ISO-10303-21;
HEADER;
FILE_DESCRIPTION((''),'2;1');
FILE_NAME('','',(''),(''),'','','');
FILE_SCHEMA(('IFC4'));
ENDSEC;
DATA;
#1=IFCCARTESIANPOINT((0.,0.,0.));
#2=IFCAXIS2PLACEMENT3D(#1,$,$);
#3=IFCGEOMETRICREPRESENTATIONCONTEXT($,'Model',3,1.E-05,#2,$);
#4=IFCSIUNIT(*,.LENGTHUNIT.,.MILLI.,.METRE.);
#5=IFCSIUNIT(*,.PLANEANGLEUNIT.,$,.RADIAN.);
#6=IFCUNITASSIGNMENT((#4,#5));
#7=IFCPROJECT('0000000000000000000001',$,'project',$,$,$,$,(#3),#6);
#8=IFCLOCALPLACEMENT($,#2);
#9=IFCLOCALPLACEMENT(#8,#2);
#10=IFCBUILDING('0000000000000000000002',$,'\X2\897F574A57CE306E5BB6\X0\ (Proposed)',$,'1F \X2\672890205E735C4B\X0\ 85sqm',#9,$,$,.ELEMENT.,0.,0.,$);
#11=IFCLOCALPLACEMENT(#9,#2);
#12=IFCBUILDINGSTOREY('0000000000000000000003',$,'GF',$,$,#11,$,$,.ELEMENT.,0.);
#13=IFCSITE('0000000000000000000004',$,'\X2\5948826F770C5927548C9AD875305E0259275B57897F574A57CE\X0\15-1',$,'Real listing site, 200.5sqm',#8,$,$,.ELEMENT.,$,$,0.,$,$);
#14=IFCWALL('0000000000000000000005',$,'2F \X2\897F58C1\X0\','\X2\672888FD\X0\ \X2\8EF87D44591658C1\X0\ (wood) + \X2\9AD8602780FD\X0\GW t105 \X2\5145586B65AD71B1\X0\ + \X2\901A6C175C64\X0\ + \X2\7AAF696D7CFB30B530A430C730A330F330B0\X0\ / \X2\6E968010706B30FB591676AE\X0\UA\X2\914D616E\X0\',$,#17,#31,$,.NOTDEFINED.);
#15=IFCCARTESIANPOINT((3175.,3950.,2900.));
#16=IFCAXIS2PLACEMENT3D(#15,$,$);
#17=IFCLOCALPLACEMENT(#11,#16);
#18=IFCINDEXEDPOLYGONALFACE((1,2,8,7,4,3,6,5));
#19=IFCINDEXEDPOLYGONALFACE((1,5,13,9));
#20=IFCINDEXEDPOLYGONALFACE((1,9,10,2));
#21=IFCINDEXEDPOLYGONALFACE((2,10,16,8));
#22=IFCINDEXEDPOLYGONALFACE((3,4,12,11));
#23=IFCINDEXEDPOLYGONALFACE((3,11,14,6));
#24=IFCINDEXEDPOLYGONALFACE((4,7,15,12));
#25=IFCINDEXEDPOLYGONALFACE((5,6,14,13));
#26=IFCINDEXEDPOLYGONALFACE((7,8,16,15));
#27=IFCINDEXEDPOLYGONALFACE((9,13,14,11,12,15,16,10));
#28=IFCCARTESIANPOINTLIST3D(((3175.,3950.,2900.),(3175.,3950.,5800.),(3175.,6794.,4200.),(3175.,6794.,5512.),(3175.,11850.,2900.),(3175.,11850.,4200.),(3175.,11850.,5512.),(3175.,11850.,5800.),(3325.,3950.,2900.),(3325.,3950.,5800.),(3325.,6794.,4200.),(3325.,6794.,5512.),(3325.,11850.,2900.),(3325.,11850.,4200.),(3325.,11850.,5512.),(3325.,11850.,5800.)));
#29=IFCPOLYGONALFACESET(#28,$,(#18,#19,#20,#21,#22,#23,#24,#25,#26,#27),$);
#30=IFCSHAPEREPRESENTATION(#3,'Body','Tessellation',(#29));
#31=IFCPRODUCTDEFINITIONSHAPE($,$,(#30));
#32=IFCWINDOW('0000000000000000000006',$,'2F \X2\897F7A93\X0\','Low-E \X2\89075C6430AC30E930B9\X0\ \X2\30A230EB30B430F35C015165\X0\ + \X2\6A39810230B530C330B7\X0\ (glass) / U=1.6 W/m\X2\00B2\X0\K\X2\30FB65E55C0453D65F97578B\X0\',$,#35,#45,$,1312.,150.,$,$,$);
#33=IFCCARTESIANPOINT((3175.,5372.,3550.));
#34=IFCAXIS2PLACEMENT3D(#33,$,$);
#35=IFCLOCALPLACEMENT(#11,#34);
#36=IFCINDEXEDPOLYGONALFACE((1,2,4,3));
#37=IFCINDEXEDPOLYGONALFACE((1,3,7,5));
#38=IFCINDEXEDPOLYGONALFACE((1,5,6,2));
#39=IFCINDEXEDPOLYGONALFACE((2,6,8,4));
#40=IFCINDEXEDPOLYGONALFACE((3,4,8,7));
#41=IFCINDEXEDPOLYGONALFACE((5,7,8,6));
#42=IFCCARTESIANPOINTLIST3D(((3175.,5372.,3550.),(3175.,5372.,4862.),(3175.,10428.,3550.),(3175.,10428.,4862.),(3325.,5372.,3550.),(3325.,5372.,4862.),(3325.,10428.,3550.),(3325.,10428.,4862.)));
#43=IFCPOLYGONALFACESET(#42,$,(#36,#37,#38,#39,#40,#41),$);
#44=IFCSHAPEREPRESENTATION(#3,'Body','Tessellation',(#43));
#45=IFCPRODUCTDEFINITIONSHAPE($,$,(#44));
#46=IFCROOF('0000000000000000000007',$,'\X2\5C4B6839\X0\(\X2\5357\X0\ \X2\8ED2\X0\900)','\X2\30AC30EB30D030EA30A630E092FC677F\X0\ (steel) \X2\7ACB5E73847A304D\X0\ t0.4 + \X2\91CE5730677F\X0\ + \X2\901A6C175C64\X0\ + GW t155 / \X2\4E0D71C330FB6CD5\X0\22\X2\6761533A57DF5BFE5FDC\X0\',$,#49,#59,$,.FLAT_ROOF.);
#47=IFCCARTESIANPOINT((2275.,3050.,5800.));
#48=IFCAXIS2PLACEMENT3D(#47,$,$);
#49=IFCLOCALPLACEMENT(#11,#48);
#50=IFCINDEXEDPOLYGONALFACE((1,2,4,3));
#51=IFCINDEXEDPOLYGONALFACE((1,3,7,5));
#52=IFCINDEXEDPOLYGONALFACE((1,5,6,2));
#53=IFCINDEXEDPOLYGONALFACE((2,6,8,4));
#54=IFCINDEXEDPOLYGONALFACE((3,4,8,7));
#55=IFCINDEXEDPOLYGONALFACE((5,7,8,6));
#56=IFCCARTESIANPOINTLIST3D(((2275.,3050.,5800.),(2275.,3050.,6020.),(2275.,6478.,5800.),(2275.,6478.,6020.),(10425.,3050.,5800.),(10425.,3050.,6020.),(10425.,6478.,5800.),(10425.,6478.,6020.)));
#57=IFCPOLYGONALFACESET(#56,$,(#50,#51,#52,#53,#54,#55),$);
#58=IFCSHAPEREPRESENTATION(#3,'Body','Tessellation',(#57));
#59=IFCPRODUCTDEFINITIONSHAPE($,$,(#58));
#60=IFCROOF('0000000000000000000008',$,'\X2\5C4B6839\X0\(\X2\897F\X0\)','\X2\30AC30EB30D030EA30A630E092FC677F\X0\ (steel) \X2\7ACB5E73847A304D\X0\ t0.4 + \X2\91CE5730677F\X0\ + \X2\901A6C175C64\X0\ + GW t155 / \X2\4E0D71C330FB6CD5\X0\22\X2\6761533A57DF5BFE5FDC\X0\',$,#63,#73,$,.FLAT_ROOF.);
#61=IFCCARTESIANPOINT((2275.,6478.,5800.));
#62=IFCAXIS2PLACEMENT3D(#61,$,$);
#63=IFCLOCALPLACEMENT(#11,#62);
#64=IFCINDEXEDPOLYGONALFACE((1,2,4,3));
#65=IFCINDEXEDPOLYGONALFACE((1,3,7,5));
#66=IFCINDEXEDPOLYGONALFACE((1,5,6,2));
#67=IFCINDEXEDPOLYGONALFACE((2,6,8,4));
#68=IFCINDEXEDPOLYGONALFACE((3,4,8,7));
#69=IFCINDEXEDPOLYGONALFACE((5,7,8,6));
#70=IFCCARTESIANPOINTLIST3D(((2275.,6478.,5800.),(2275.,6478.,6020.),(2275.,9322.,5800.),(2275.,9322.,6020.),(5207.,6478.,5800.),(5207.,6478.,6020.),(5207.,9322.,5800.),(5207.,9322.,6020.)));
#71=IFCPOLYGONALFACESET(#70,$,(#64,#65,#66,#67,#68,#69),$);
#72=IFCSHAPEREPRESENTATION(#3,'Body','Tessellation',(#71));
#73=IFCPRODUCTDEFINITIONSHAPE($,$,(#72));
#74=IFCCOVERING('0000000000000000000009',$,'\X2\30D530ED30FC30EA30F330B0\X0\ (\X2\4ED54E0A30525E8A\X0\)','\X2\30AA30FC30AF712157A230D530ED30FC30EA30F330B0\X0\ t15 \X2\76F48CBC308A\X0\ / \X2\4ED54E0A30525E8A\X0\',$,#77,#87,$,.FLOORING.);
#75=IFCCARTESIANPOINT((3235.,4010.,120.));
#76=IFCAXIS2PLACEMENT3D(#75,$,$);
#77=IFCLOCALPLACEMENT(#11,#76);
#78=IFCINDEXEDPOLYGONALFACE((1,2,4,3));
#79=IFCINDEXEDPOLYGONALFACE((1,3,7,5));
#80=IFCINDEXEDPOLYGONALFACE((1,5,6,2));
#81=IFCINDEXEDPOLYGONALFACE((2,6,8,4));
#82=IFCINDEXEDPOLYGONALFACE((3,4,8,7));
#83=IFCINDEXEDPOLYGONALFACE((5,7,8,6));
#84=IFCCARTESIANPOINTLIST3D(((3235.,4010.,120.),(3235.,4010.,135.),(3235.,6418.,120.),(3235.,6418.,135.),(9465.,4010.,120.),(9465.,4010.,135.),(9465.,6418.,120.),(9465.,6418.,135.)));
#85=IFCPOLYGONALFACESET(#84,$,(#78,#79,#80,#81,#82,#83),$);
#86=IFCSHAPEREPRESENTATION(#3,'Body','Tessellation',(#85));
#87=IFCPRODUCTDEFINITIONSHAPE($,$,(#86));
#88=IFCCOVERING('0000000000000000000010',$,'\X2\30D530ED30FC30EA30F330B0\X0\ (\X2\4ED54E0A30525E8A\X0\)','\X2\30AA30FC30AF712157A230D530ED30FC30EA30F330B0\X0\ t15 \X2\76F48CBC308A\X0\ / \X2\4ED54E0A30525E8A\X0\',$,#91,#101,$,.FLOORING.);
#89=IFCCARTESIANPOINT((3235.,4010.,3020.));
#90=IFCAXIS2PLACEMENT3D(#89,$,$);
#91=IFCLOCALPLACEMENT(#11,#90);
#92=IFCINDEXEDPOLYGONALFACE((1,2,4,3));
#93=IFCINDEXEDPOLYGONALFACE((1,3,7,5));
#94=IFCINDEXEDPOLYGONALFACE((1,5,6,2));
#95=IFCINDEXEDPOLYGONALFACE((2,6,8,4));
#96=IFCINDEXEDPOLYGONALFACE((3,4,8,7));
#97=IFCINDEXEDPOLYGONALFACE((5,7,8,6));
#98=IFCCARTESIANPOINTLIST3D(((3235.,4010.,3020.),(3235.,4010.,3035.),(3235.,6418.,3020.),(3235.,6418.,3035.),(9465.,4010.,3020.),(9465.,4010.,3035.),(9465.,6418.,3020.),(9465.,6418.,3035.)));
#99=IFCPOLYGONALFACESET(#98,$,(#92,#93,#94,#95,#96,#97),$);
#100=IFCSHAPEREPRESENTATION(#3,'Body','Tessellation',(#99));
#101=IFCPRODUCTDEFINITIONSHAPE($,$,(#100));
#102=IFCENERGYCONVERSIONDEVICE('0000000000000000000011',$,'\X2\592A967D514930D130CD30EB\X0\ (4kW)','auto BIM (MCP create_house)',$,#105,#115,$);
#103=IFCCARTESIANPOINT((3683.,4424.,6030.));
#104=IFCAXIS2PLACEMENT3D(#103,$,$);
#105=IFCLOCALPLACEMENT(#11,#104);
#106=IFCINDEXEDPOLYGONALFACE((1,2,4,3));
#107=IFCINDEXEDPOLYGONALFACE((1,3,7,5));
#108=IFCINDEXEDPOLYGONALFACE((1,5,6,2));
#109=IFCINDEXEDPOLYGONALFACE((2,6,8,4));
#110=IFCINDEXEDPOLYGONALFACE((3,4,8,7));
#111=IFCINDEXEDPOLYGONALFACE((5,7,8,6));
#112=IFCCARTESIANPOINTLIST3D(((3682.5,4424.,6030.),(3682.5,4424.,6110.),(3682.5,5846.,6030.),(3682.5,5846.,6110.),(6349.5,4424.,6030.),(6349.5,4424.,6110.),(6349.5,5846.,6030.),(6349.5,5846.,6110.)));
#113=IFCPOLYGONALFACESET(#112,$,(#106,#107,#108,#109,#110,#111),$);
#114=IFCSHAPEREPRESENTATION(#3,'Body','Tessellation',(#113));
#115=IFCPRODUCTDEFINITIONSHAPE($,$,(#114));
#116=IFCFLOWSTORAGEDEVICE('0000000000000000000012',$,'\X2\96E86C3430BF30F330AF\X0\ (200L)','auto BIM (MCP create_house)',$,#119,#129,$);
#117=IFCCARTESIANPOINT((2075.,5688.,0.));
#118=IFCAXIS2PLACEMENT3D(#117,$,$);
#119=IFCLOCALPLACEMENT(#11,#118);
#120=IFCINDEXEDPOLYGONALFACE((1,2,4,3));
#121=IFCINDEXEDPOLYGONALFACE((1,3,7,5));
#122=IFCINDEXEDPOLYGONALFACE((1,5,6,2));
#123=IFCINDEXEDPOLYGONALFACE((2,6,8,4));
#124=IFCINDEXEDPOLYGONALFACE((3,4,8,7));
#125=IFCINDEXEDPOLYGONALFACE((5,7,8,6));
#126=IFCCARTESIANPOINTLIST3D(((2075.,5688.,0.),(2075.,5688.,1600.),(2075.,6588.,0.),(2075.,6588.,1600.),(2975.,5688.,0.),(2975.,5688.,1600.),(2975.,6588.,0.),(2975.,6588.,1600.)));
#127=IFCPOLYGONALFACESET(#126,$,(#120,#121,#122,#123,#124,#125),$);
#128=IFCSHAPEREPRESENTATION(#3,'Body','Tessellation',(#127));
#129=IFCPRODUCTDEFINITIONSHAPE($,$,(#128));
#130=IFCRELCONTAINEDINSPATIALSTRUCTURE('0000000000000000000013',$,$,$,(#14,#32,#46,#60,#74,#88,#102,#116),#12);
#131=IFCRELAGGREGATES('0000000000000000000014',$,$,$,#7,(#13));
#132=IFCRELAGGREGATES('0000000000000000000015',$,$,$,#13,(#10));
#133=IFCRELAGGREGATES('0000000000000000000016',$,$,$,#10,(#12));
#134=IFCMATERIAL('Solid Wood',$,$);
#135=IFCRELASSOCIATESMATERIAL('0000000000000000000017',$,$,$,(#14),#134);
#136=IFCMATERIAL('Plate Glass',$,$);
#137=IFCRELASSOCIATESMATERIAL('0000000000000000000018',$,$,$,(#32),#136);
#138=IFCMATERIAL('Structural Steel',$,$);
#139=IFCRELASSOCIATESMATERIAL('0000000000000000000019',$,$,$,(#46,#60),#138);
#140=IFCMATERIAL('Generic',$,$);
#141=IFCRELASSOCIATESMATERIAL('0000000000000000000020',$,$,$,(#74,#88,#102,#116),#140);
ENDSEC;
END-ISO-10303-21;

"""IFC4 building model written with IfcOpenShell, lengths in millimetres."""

from ifc_helpers import new_model, si_unit, frame, frame_2d, origin, place, context, project, spatial, rectangle, extrude, material, element, fill, save


model = new_model("IFC4")

# Units and contexts
model_context = context("Model", 3, precision=1e-05, world=origin())
ifc_project = project(units=[si_unit("LENGTHUNIT", "METRE", prefix="MILLI"), si_unit("PLANEANGLEUNIT", "RADIAN")], contexts=[model_context])

# Site, building, storey
site_placement = place(None, origin())
site = spatial("IfcSite", under=ifc_project, at=site_placement, Name="奈良県大和高田市大字西坊城15-1", ObjectType="Real listing site, 200.5sqm", CompositionType="ELEMENT", RefElevation=0.0)
building_placement = place(site_placement, origin())
building = spatial("IfcBuilding", under=site, at=building_placement, Name="西坊城の家 (Proposed)", ObjectType="1F 木造平屋 85sqm", CompositionType="ELEMENT", ElevationOfRefHeight=0.0, ElevationOfTerrain=0.0)
storey_placement = place(building_placement, origin())
storey = spatial("IfcBuildingStorey", under=building, at=storey_placement, Name="GF", CompositionType="ELEMENT", Elevation=0.0)

# Shared definitions
ifc_material_1 = material(Name="Solid Wood")
ifc_material_2 = material(Name="Generic")

# Shared definitions
ifc_material_3 = material(Name="Plate Glass")

# Wall, opening, window
wall_1_placement = place(storey_placement, frame((3175.0, 3950.0, 2900.0)))
wall_1 = element("IfcWall", 1, at=wall_1_placement, inside=storey, material=ifc_material_1, Name="2F 西壁", Description="木製 軸組外壁 (wood) + 高性能GW t105 充填断熱 + 通気層 + 窯業系サイディング / 準耐火・外皮UA配慮", PredefinedType="NOTDEFINED", context=model_context, shape_type="SweptSolid", body=[
    extrude(rectangle(XDim=150.0, YDim=7900.0, at=frame_2d((75.0, 3950.0))), frame((3175.0, 3950.0, 2900.0)), (0.0, 0.0, 1.0), 2900.0),
])
opening_1_placement = place(storey_placement, frame((3175.0, 5372.0, 3550.0)))
opening_1 = element("IfcOpeningElement", 2, at=opening_1_placement, cuts=wall_1, PredefinedType="NOTDEFINED", context=model_context, shape_type="SweptSolid", body=[
    extrude(rectangle(XDim=150.0, YDim=5056.0, at=frame_2d((75.0, 2528.0))), frame((3175.0, 5372.0, 3550.0)), (0.0, 0.0, 1.0), 1312.0),
])
window_1_placement = place(storey_placement, frame((3175.0, 5372.0, 3550.0)))
window_1 = element("IfcWindow", 3, at=window_1_placement, inside=storey, material=ifc_material_3, Name="2F 西窓", Description="Low-E 複層ガラス アルゴン封入 + 樹脂サッシ (glass) / U=1.6 W/m²K・日射取得型", OverallHeight=1312.0, OverallWidth=150.0, context=model_context, shape_type="SweptSolid", body=[
    extrude(rectangle(XDim=150.0, YDim=5056.0, at=frame_2d((75.0, 2528.0))), frame((3175.0, 5372.0, 3550.0)), (0.0, 0.0, 1.0), 1312.0),
])
fill(opening_1, window_1)

# Roofs
ifc_material_4 = material(Name="Structural Steel")
roof_1_placement = place(storey_placement, frame((2275.0, 3050.0, 5800.0)))
element("IfcRoof", 4, at=roof_1_placement, inside=storey, material=ifc_material_4, Name="屋根(南 軒900)", Description="ガルバリウム鋼板 (steel) 立平葺き t0.4 + 野地板 + 通気層 + GW t155 / 不燃・法22条区域対応", PredefinedType="FLAT_ROOF", context=model_context, shape_type="SweptSolid", body=[
    extrude(rectangle(XDim=8150.0, YDim=3428.0, at=frame_2d((4075.0, 1714.0))), frame((2275.0, 3050.0, 5800.0)), (0.0, 0.0, 1.0), 220.0),
])
roof_2_placement = place(storey_placement, frame((2275.0, 6478.0, 5800.0)))
element("IfcRoof", 5, at=roof_2_placement, inside=storey, material=ifc_material_4, Name="屋根(西)", Description="ガルバリウム鋼板 (steel) 立平葺き t0.4 + 野地板 + 通気層 + GW t155 / 不燃・法22条区域対応", PredefinedType="FLAT_ROOF", context=model_context, shape_type="SweptSolid", body=[
    extrude(rectangle(XDim=2932.0, YDim=2844.0, at=frame_2d((1466.0, 1422.0))), frame((2275.0, 6478.0, 5800.0)), (0.0, 0.0, 1.0), 220.0),
])

# Coverings
covering_1_placement = place(storey_placement, frame((3235.0, 4010.0, 120.0)))
element("IfcCovering", 6, at=covering_1_placement, inside=storey, material=ifc_material_2, Name="フローリング (仕上げ床)", Description="オーク無垢フローリング t15 直貼り / 仕上げ床", PredefinedType="FLOORING", context=model_context, shape_type="SweptSolid", body=[
    extrude(rectangle(XDim=6230.0, YDim=2408.0, at=frame_2d((3115.0, 1204.0))), frame((3235.0, 4010.0, 120.0)), (0.0, 0.0, 1.0), 15.0),
])
covering_2_placement = place(storey_placement, frame((3235.0, 4010.0, 3020.0)))
element("IfcCovering", 7, at=covering_2_placement, inside=storey, material=ifc_material_2, Name="フローリング (仕上げ床)", Description="オーク無垢フローリング t15 直貼り / 仕上げ床", PredefinedType="FLOORING", context=model_context, shape_type="SweptSolid", body=[
    extrude(rectangle(XDim=6230.0, YDim=2408.0, at=frame_2d((3115.0, 1204.0))), frame((3235.0, 4010.0, 3020.0)), (0.0, 0.0, 1.0), 15.0),
])

# Energy conversion device
energy_conversion_device_placement = place(storey_placement, frame((3683.0, 4424.0, 6030.0)))
element("IfcEnergyConversionDevice", 8, at=energy_conversion_device_placement, inside=storey, material=ifc_material_2, Name="太陽光パネル (4kW)", Description="auto BIM (MCP create_house)", context=model_context, shape_type="SweptSolid", body=[
    extrude(rectangle(XDim=2667.0, YDim=1422.0, at=frame_2d((1333.0, 711.0))), frame((3683.0, 4424.0, 6030.0)), (0.0, 0.0, 1.0), 80.0),
])

# Flow storage device
flow_storage_device_placement = place(storey_placement, frame((2075.0, 5688.0, 0.0)))
element("IfcFlowStorageDevice", 9, at=flow_storage_device_placement, inside=storey, material=ifc_material_2, Name="雨水タンク (200L)", Description="auto BIM (MCP create_house)", context=model_context, shape_type="SweptSolid", body=[
    extrude(rectangle(XDim=900.0, YDim=900.0, at=frame_2d((450.0, 450.0))), frame((2075.0, 5688.0, 0.0)), (0.0, 0.0, 1.0), 1600.0),
])

save(model, "model.ifc")
